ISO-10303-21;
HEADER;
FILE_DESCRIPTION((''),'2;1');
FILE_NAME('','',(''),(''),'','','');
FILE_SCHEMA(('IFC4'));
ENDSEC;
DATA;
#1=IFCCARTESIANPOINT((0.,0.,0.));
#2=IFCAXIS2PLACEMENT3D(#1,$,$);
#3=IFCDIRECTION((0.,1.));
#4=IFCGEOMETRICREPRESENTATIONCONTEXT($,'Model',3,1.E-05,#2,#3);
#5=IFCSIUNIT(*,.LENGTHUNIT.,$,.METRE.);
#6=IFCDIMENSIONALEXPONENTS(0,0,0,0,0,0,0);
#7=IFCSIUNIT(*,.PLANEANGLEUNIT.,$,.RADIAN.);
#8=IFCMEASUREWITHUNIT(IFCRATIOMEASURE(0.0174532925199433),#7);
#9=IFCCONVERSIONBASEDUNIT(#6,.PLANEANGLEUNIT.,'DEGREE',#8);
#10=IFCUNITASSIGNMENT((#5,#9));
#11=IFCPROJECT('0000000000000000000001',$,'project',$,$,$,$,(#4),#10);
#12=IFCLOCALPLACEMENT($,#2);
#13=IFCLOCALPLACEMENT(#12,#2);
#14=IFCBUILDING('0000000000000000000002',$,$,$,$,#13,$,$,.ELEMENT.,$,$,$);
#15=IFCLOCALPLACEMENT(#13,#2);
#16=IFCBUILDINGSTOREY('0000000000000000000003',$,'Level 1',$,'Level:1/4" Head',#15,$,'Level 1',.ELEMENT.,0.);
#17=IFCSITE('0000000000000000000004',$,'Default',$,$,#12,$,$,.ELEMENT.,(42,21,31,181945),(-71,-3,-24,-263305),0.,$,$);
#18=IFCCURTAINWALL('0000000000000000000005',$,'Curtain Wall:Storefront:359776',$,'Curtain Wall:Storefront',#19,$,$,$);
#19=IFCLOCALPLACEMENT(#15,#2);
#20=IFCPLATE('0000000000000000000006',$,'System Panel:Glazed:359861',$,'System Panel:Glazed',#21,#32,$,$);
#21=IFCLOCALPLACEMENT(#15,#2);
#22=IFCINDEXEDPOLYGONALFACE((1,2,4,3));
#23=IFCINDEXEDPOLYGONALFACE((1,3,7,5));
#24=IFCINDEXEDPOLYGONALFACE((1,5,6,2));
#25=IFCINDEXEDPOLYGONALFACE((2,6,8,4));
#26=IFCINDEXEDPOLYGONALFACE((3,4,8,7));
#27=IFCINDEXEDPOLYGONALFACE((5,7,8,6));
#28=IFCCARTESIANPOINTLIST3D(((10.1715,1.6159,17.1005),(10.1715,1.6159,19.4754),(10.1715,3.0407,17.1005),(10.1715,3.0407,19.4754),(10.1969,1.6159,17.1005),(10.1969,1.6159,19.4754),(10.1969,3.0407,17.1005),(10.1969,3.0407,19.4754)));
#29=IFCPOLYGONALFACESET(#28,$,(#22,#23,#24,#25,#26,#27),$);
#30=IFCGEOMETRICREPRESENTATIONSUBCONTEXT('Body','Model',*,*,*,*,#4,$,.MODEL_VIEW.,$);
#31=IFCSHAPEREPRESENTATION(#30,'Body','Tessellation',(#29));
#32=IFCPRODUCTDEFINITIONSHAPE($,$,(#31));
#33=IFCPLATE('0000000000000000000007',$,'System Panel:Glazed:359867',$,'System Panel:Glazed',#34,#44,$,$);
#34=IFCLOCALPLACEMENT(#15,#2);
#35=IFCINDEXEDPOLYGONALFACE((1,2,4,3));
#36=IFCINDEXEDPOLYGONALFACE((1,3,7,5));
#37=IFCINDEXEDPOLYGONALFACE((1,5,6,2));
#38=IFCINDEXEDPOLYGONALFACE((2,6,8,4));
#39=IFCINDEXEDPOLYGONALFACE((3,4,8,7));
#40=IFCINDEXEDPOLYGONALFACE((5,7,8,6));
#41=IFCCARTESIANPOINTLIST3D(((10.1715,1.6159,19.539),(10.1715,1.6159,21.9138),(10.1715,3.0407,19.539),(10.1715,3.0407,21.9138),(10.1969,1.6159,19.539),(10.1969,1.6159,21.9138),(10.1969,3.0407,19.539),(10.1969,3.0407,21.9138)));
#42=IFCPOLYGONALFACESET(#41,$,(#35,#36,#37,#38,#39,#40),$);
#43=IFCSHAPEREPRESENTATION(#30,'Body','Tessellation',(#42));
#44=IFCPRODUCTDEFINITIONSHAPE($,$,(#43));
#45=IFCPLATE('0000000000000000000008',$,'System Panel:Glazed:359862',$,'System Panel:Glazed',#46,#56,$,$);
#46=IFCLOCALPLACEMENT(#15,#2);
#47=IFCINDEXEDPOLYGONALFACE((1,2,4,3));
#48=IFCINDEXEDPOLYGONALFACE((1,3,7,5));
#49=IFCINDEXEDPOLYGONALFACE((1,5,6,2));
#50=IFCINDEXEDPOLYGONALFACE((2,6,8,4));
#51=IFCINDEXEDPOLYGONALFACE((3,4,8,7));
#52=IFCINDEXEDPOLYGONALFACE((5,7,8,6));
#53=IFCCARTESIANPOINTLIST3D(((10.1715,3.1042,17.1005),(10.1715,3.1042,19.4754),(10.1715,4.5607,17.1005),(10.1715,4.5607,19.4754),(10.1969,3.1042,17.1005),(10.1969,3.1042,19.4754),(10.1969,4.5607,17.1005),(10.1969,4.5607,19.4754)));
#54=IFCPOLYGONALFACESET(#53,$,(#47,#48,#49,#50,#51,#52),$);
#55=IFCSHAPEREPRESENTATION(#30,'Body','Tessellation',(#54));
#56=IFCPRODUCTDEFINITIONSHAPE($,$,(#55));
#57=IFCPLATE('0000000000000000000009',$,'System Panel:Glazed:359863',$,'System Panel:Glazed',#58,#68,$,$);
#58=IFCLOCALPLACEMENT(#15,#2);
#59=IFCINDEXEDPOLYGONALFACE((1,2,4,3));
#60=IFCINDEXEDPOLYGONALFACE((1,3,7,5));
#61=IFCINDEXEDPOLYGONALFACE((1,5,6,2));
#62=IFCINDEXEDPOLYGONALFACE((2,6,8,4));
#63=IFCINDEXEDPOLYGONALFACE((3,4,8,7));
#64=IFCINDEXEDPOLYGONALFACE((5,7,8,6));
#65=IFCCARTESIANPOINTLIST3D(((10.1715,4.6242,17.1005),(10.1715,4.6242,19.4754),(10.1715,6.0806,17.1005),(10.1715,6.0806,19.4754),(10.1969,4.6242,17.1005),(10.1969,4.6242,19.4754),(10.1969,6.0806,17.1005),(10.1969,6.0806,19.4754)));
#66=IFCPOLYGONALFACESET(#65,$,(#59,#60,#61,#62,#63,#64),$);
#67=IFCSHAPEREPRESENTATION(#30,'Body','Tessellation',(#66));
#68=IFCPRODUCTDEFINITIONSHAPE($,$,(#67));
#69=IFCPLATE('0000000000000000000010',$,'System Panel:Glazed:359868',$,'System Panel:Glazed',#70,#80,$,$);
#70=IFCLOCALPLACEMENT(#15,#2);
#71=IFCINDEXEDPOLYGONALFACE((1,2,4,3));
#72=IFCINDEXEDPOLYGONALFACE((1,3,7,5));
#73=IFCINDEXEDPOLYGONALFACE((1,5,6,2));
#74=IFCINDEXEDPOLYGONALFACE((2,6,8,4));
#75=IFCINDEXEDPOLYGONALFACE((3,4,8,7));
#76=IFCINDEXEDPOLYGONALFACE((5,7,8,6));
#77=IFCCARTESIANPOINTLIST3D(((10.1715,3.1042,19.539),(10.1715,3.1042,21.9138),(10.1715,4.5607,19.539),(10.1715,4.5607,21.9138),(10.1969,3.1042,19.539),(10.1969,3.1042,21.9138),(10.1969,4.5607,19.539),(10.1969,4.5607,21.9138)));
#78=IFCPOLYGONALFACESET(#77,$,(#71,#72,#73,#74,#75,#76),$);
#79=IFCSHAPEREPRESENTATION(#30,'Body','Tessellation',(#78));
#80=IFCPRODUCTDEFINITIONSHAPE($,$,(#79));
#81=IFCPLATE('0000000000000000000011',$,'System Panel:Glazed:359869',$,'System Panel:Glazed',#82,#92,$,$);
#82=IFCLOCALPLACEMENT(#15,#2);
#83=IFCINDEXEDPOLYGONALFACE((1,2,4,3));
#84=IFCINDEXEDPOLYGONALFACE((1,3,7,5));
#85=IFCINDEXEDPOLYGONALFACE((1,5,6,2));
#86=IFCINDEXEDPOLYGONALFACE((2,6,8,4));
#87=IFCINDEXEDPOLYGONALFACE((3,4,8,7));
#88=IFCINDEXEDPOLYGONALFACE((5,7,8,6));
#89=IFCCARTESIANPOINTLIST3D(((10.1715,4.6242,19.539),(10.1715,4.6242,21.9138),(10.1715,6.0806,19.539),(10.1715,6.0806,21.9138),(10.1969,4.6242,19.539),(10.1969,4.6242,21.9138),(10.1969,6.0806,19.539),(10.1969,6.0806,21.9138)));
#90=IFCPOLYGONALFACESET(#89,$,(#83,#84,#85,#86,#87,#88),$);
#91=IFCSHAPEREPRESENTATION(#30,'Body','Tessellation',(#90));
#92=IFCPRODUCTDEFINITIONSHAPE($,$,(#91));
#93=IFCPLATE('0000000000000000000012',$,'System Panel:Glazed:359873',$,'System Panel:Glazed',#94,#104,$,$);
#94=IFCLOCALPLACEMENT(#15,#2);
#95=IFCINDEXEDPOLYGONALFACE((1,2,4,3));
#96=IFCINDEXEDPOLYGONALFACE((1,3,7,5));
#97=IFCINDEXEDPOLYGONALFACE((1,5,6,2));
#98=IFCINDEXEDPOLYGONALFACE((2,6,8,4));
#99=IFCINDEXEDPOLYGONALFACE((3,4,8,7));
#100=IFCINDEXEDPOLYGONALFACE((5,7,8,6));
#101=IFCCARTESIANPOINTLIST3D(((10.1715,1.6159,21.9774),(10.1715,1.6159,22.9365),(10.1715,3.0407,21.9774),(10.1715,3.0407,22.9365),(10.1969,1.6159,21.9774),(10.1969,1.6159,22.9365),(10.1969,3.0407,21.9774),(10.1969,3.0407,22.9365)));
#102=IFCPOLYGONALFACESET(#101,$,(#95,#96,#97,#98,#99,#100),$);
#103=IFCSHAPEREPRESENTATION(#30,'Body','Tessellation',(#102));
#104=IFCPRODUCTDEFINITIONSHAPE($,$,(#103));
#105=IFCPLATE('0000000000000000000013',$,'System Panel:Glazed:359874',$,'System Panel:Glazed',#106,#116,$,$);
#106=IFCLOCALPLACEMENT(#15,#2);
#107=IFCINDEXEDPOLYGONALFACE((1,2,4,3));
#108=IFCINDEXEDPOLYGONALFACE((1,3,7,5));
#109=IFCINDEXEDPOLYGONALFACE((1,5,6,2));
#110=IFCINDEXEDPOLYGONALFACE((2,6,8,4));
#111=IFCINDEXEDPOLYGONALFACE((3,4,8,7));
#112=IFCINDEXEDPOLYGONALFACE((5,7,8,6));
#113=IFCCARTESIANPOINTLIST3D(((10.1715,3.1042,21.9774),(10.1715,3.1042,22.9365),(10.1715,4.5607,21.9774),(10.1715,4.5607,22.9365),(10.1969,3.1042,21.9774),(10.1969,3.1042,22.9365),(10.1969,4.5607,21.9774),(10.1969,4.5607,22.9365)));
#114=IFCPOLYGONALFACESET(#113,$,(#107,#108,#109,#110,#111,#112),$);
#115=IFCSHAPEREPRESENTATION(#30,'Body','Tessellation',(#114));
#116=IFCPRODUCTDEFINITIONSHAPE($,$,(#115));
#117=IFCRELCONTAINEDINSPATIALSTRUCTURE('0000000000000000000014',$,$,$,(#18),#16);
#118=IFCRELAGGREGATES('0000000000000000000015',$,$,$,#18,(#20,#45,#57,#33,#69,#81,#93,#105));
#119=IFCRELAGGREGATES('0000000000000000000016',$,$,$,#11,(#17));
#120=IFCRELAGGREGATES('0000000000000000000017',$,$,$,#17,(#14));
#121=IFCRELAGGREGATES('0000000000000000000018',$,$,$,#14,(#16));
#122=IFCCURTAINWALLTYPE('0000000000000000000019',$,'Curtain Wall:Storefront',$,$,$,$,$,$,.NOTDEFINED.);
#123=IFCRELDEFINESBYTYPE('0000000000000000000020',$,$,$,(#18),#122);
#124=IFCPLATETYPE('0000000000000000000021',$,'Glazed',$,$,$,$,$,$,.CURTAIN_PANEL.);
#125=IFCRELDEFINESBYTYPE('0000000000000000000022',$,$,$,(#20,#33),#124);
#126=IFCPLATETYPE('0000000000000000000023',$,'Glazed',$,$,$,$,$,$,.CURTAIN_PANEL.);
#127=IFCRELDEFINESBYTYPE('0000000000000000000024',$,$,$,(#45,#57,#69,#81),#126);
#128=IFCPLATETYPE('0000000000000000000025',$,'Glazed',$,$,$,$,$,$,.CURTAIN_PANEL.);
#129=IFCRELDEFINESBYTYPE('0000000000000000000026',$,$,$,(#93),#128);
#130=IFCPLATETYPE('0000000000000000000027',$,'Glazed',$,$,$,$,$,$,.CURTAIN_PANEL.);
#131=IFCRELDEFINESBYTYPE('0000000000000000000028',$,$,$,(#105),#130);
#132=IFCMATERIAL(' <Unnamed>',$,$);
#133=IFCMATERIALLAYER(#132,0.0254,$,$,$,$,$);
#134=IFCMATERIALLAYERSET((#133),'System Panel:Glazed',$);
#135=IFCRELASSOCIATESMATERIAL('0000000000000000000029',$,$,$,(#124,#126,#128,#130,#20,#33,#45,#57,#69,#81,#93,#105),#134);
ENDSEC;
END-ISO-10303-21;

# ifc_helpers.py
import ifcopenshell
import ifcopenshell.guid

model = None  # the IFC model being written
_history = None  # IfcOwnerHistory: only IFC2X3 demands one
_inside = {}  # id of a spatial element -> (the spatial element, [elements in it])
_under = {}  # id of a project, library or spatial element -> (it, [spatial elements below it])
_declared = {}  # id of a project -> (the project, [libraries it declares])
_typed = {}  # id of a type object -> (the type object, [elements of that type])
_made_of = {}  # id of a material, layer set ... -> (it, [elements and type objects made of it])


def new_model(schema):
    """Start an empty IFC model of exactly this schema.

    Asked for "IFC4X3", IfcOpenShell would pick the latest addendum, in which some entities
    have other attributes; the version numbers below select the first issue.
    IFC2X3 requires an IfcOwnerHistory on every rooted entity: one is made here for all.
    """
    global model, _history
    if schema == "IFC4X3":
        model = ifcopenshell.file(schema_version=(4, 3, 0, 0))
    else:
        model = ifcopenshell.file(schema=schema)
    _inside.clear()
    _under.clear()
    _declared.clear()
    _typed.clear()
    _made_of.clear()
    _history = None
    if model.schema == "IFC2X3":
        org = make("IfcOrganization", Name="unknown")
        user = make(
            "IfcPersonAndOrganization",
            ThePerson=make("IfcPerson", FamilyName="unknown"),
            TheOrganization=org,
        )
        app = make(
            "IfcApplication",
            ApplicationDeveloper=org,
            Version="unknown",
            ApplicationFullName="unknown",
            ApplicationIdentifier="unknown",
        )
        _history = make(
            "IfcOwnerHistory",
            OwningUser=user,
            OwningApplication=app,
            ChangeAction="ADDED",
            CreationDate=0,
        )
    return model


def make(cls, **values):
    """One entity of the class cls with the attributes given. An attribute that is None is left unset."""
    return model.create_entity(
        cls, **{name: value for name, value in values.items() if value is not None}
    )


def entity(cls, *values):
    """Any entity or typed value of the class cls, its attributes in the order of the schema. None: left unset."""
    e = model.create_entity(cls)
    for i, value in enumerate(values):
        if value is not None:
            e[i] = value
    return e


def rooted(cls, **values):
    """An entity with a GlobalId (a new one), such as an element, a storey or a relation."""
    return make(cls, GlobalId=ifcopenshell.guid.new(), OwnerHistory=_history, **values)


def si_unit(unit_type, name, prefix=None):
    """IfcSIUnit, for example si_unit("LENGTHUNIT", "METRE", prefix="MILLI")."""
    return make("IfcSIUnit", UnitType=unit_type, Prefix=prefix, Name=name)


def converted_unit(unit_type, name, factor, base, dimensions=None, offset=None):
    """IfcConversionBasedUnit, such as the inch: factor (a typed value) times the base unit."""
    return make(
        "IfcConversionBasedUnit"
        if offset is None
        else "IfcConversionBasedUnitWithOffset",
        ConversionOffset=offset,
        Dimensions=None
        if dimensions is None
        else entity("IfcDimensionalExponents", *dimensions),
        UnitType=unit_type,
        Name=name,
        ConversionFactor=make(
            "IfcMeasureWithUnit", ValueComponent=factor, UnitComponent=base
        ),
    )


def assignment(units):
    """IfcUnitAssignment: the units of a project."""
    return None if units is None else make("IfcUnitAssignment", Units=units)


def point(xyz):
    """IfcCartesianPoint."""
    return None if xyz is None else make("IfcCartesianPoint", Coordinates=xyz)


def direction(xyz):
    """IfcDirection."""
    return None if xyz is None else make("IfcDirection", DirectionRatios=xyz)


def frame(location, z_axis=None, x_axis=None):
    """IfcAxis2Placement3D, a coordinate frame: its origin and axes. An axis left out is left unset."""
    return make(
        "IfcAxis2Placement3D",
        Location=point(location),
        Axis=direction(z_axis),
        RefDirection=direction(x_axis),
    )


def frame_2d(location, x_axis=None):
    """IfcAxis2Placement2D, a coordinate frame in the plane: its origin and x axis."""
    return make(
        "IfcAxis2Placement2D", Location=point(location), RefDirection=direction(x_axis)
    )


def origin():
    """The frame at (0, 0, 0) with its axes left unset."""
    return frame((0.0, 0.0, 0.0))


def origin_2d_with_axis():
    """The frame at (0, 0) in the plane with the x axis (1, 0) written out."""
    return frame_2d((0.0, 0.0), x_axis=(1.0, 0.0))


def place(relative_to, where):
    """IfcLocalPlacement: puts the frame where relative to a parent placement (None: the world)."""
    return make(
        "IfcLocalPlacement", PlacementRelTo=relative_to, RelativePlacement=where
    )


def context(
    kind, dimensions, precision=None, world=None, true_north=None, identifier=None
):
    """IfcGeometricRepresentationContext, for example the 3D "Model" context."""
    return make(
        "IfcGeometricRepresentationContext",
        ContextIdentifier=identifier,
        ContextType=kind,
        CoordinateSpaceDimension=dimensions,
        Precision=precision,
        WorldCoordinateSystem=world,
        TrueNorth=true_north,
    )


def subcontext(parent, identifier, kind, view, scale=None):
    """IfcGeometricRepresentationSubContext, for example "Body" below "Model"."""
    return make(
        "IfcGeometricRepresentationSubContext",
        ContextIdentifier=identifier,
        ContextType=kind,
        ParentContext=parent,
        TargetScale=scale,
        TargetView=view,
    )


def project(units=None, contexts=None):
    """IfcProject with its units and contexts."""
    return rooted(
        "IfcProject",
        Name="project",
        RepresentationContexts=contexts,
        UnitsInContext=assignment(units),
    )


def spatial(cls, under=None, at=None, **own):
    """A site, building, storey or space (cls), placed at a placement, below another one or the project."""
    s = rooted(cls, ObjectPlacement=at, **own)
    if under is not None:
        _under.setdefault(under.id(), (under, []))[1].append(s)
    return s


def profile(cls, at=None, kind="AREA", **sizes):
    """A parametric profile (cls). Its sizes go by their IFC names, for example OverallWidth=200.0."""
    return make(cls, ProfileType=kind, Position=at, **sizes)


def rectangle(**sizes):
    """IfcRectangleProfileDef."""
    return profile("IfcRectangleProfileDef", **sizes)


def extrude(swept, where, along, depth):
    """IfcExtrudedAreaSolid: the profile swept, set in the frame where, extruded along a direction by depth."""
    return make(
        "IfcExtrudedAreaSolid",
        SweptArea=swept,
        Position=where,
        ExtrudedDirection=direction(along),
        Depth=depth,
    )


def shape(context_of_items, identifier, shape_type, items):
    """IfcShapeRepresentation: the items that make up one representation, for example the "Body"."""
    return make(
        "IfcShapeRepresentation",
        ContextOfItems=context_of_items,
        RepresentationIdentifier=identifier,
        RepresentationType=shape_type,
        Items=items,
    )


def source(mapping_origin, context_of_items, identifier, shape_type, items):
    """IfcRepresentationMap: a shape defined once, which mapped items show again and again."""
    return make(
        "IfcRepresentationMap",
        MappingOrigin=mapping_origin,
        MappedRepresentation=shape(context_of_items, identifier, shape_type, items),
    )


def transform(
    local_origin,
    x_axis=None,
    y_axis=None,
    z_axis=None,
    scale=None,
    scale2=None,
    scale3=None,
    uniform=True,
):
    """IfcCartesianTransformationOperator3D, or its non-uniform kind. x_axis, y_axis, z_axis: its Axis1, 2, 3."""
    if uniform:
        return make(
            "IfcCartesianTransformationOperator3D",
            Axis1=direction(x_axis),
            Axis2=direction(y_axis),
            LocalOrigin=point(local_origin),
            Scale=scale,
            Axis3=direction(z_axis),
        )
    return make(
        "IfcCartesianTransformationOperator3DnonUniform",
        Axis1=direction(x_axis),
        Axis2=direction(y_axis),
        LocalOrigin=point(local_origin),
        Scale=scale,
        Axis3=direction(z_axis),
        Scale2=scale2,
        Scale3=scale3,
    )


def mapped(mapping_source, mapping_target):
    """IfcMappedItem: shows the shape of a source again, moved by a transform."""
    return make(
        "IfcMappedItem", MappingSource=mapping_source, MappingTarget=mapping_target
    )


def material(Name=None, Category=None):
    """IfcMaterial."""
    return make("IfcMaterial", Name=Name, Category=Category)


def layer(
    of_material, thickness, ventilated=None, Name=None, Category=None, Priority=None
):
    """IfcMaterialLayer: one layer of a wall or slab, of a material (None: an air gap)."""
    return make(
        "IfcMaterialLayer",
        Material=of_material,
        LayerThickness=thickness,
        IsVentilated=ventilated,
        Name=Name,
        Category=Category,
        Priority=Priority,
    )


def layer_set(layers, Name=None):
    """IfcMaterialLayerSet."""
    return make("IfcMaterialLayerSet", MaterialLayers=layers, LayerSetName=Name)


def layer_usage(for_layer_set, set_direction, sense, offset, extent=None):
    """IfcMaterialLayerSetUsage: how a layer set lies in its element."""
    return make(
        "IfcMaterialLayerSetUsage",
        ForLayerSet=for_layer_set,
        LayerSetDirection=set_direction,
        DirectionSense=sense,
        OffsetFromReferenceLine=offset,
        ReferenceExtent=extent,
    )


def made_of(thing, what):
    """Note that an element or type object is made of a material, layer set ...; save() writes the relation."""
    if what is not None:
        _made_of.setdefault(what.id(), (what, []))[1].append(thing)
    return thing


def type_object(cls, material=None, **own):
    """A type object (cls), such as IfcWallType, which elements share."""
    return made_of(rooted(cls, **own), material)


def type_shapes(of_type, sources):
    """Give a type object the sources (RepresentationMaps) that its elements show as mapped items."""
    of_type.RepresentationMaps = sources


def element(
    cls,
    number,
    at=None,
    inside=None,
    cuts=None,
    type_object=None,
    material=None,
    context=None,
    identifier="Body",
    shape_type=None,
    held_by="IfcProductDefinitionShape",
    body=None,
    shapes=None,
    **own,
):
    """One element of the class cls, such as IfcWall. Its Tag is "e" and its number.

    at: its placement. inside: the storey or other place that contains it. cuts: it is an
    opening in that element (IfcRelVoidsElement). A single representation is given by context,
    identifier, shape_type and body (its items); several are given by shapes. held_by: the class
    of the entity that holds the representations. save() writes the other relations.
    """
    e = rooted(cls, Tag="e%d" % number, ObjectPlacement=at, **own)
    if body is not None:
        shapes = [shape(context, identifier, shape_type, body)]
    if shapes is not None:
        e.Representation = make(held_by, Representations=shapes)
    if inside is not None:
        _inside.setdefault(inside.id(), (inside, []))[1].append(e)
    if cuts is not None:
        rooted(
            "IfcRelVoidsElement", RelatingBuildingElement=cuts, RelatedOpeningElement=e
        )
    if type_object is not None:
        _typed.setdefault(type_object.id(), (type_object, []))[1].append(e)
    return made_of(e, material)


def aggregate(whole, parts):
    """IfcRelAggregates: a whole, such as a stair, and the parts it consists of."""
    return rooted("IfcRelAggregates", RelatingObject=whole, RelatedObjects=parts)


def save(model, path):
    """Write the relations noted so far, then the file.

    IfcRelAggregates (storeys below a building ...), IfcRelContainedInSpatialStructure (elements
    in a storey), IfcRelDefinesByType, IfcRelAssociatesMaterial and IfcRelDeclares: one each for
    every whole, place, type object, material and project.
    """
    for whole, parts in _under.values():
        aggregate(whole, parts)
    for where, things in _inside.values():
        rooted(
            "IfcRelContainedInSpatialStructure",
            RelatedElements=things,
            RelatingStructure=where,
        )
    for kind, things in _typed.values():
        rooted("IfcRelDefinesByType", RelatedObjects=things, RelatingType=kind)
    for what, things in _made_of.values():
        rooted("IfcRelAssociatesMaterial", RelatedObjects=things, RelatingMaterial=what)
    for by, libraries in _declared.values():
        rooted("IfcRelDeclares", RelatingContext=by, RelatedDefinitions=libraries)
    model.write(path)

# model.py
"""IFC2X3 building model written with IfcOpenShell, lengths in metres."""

from ifc_helpers import new_model, entity, si_unit, converted_unit, direction, frame, frame_2d, origin, origin_2d_with_axis, place, context, subcontext, project, spatial, rectangle, extrude, source, transform, mapped, material, layer, layer_set, layer_usage, type_object, type_shapes, element, aggregate, save


model = new_model("IFC2X3")

# Units and contexts
model_context = context("Model", 3, precision=1e-05, world=origin(), true_north=direction((0.0, 1.0)))
body_context = subcontext(model_context, "Body", "Model", "MODEL_VIEW")
ifc_project = project(units=[si_unit("LENGTHUNIT", "METRE"), converted_unit("PLANEANGLEUNIT", "DEGREE", entity("IfcRatioMeasure", 0.0174532925199433), si_unit("PLANEANGLEUNIT", "RADIAN"), dimensions=[0, 0, 0, 0, 0, 0, 0])], contexts=[model_context])

# Site, building, storey
site_placement = place(None, origin())
site = spatial("IfcSite", under=ifc_project, at=site_placement, Name="Default", CompositionType="ELEMENT", RefLatitude=(42, 21, 31, 181945), RefLongitude=(-71, -3, -24, -263305), RefElevation=0.0)
building_placement = place(site_placement, origin())
building = spatial("IfcBuilding", under=site, at=building_placement, CompositionType="ELEMENT")
storey_placement = place(building_placement, origin())
storey = spatial("IfcBuildingStorey", under=building, at=storey_placement, Name="Level 1", ObjectType="Level:1/4\" Head", LongName="Level 1", CompositionType="ELEMENT", Elevation=0.0)

# Curtain wall, plates
curtain_wall_type = type_object("IfcCurtainWallType", Name="Curtain Wall:Storefront", PredefinedType="NOTDEFINED")
curtain_wall_placement = place(storey_placement, origin())
curtain_wall = element("IfcCurtainWall", 1, at=curtain_wall_placement, inside=storey, type_object=curtain_wall_type, Name="Curtain Wall:Storefront:359776", ObjectType="Curtain Wall:Storefront")
ifc_material_1 = material(Name=" <Unnamed>")
ifc_layer = layer(ifc_material_1, 0.0254)
ifc_layer_set = layer_set([ifc_layer], Name="System Panel:Glazed")
ifc_layer_usage_1 = layer_usage(ifc_layer_set, "AXIS3", "POSITIVE", 0.1042)
plate_type_1 = type_object("IfcPlateType", Name="Glazed", PredefinedType="CURTAIN_PANEL", material=ifc_layer_set)
shared_shape_1 = source(origin(), body_context, "Body", "SweptSolid", [
    extrude(rectangle(XDim=0.0254, YDim=1.4248, at=frame_2d((0.0, 0.0), x_axis=(1.0, 0.0))), frame((0.7124, 0.0127, 0.0), z_axis=(0.0, 0.0, 1.0), x_axis=(0.0, 1.0, 0.0)), (0.0, 0.0, 1.0), 2.3749),
])
type_shapes(plate_type_1, [shared_shape_1])
plate_1_placement = place(curtain_wall_placement, frame((10.1969, 1.6159, 17.1005), z_axis=(0.0, 0.0, 1.0), x_axis=(0.0, 1.0, 0.0)))
plate_1 = element("IfcPlate", 2, at=plate_1_placement, type_object=plate_type_1, material=ifc_layer_usage_1, Name="System Panel:Glazed:359861", ObjectType="System Panel:Glazed", context=body_context, shape_type="MappedRepresentation", body=[
    mapped(shared_shape_1, transform((0.0, 0.0, 0.0), scale=1.0)),
])
ifc_layer_usage_2 = layer_usage(ifc_layer_set, "AXIS3", "POSITIVE", 0.1042)
plate_2_placement = place(curtain_wall_placement, frame((10.1969, 1.6159, 19.5389), z_axis=(0.0, 0.0, 1.0), x_axis=(0.0, 1.0, 0.0)))
plate_2 = element("IfcPlate", 3, at=plate_2_placement, type_object=plate_type_1, material=ifc_layer_usage_2, Name="System Panel:Glazed:359867", ObjectType="System Panel:Glazed", context=body_context, shape_type="MappedRepresentation", body=[
    mapped(shared_shape_1, transform((0.0, 0.0, 0.0), scale=1.0)),
])
ifc_layer_usage_3 = layer_usage(ifc_layer_set, "AXIS3", "POSITIVE", 0.1042)
plate_type_2 = type_object("IfcPlateType", Name="Glazed", PredefinedType="CURTAIN_PANEL", material=ifc_layer_set)
shared_shape_2 = source(origin(), body_context, "Body", "SweptSolid", [
    extrude(rectangle(XDim=0.0254, YDim=1.4565, at=origin_2d_with_axis()), frame((0.7282, 0.0127, 0.0), z_axis=(0.0, 0.0, 1.0), x_axis=(0.0, 1.0, 0.0)), (0.0, 0.0, 1.0), 2.3749),
])
type_shapes(plate_type_2, [shared_shape_2])
plate_3_placement = place(curtain_wall_placement, frame((10.1969, 3.1042, 17.1005), z_axis=(0.0, 0.0, 1.0), x_axis=(0.0, 1.0, 0.0)))
plate_3 = element("IfcPlate", 4, at=plate_3_placement, type_object=plate_type_2, material=ifc_layer_usage_3, Name="System Panel:Glazed:359862", ObjectType="System Panel:Glazed", context=body_context, shape_type="MappedRepresentation", body=[
    mapped(shared_shape_2, transform((0.0, 0.0, 0.0), scale=1.0)),
])
ifc_layer_usage_4 = layer_usage(ifc_layer_set, "AXIS3", "POSITIVE", 0.1042)
plate_4_placement = place(curtain_wall_placement, frame((10.1969, 4.6242, 17.1005), z_axis=(0.0, 0.0, 1.0), x_axis=(0.0, 1.0, 0.0)))
plate_4 = element("IfcPlate", 5, at=plate_4_placement, type_object=plate_type_2, material=ifc_layer_usage_4, Name="System Panel:Glazed:359863", ObjectType="System Panel:Glazed", context=body_context, shape_type="MappedRepresentation", body=[
    mapped(shared_shape_2, transform((0.0, 0.0, 0.0), scale=1.0)),
])
ifc_layer_usage_5 = layer_usage(ifc_layer_set, "AXIS3", "POSITIVE", 0.1042)
plate_5_placement = place(curtain_wall_placement, frame((10.1969, 3.1042, 19.5389), z_axis=(0.0, 0.0, 1.0), x_axis=(0.0, 1.0, 0.0)))
plate_5 = element("IfcPlate", 6, at=plate_5_placement, type_object=plate_type_2, material=ifc_layer_usage_5, Name="System Panel:Glazed:359868", ObjectType="System Panel:Glazed", context=body_context, shape_type="MappedRepresentation", body=[
    mapped(shared_shape_2, transform((0.0, 0.0, 0.0), scale=1.0)),
])
ifc_layer_usage_6 = layer_usage(ifc_layer_set, "AXIS3", "POSITIVE", 0.1042)
plate_6_placement = place(curtain_wall_placement, frame((10.1969, 4.6242, 19.5389), z_axis=(0.0, 0.0, 1.0), x_axis=(0.0, 1.0, 0.0)))
plate_6 = element("IfcPlate", 7, at=plate_6_placement, type_object=plate_type_2, material=ifc_layer_usage_6, Name="System Panel:Glazed:359869", ObjectType="System Panel:Glazed", context=body_context, shape_type="MappedRepresentation", body=[
    mapped(shared_shape_2, transform((0.0, 0.0, 0.0), scale=1.0)),
])
ifc_layer_usage_7 = layer_usage(ifc_layer_set, "AXIS3", "POSITIVE", 0.1042)
plate_type_3 = type_object("IfcPlateType", Name="Glazed", PredefinedType="CURTAIN_PANEL", material=ifc_layer_set)
shared_shape_3 = source(origin(), body_context, "Body", "SweptSolid", [
    extrude(rectangle(XDim=0.0254, YDim=1.4248, at=frame_2d((0.0, 0.0), x_axis=(1.0, 0.0))), frame((0.7124, 0.0127, 0.0), z_axis=(0.0, 0.0, 1.0), x_axis=(0.0, 1.0, 0.0)), (0.0, 0.0, 1.0), 0.9592),
])
type_shapes(plate_type_3, [shared_shape_3])
plate_7_placement = place(curtain_wall_placement, frame((10.1969, 1.6159, 21.9774), z_axis=(0.0, 0.0, 1.0), x_axis=(0.0, 1.0, 0.0)))
plate_7 = element("IfcPlate", 8, at=plate_7_placement, type_object=plate_type_3, material=ifc_layer_usage_7, Name="System Panel:Glazed:359873", ObjectType="System Panel:Glazed", context=body_context, shape_type="MappedRepresentation", body=[
    mapped(shared_shape_3, transform((0.0, 0.0, 0.0), scale=1.0)),
])
ifc_layer_usage_8 = layer_usage(ifc_layer_set, "AXIS3", "POSITIVE", 0.1042)
plate_type_4 = type_object("IfcPlateType", Name="Glazed", PredefinedType="CURTAIN_PANEL", material=ifc_layer_set)
shared_shape_4 = source(origin(), body_context, "Body", "SweptSolid", [
    extrude(rectangle(XDim=0.0254, YDim=1.4565, at=origin_2d_with_axis()), frame((0.7282, 0.0127, 0.0), z_axis=(0.0, 0.0, 1.0), x_axis=(0.0, 1.0, 0.0)), (0.0, 0.0, 1.0), 0.9592),
])
type_shapes(plate_type_4, [shared_shape_4])
plate_8_placement = place(curtain_wall_placement, frame((10.1969, 3.1042, 21.9774), z_axis=(0.0, 0.0, 1.0), x_axis=(0.0, 1.0, 0.0)))
plate_8 = element("IfcPlate", 9, at=plate_8_placement, type_object=plate_type_4, material=ifc_layer_usage_8, Name="System Panel:Glazed:359874", ObjectType="System Panel:Glazed", context=body_context, shape_type="MappedRepresentation", body=[
    mapped(shared_shape_4, transform((0.0, 0.0, 0.0), scale=1.0)),
])
aggregate(curtain_wall, [plate_1, plate_3, plate_4, plate_2, plate_5, plate_6, plate_7, plate_8])

save(model, "model.ifc")
